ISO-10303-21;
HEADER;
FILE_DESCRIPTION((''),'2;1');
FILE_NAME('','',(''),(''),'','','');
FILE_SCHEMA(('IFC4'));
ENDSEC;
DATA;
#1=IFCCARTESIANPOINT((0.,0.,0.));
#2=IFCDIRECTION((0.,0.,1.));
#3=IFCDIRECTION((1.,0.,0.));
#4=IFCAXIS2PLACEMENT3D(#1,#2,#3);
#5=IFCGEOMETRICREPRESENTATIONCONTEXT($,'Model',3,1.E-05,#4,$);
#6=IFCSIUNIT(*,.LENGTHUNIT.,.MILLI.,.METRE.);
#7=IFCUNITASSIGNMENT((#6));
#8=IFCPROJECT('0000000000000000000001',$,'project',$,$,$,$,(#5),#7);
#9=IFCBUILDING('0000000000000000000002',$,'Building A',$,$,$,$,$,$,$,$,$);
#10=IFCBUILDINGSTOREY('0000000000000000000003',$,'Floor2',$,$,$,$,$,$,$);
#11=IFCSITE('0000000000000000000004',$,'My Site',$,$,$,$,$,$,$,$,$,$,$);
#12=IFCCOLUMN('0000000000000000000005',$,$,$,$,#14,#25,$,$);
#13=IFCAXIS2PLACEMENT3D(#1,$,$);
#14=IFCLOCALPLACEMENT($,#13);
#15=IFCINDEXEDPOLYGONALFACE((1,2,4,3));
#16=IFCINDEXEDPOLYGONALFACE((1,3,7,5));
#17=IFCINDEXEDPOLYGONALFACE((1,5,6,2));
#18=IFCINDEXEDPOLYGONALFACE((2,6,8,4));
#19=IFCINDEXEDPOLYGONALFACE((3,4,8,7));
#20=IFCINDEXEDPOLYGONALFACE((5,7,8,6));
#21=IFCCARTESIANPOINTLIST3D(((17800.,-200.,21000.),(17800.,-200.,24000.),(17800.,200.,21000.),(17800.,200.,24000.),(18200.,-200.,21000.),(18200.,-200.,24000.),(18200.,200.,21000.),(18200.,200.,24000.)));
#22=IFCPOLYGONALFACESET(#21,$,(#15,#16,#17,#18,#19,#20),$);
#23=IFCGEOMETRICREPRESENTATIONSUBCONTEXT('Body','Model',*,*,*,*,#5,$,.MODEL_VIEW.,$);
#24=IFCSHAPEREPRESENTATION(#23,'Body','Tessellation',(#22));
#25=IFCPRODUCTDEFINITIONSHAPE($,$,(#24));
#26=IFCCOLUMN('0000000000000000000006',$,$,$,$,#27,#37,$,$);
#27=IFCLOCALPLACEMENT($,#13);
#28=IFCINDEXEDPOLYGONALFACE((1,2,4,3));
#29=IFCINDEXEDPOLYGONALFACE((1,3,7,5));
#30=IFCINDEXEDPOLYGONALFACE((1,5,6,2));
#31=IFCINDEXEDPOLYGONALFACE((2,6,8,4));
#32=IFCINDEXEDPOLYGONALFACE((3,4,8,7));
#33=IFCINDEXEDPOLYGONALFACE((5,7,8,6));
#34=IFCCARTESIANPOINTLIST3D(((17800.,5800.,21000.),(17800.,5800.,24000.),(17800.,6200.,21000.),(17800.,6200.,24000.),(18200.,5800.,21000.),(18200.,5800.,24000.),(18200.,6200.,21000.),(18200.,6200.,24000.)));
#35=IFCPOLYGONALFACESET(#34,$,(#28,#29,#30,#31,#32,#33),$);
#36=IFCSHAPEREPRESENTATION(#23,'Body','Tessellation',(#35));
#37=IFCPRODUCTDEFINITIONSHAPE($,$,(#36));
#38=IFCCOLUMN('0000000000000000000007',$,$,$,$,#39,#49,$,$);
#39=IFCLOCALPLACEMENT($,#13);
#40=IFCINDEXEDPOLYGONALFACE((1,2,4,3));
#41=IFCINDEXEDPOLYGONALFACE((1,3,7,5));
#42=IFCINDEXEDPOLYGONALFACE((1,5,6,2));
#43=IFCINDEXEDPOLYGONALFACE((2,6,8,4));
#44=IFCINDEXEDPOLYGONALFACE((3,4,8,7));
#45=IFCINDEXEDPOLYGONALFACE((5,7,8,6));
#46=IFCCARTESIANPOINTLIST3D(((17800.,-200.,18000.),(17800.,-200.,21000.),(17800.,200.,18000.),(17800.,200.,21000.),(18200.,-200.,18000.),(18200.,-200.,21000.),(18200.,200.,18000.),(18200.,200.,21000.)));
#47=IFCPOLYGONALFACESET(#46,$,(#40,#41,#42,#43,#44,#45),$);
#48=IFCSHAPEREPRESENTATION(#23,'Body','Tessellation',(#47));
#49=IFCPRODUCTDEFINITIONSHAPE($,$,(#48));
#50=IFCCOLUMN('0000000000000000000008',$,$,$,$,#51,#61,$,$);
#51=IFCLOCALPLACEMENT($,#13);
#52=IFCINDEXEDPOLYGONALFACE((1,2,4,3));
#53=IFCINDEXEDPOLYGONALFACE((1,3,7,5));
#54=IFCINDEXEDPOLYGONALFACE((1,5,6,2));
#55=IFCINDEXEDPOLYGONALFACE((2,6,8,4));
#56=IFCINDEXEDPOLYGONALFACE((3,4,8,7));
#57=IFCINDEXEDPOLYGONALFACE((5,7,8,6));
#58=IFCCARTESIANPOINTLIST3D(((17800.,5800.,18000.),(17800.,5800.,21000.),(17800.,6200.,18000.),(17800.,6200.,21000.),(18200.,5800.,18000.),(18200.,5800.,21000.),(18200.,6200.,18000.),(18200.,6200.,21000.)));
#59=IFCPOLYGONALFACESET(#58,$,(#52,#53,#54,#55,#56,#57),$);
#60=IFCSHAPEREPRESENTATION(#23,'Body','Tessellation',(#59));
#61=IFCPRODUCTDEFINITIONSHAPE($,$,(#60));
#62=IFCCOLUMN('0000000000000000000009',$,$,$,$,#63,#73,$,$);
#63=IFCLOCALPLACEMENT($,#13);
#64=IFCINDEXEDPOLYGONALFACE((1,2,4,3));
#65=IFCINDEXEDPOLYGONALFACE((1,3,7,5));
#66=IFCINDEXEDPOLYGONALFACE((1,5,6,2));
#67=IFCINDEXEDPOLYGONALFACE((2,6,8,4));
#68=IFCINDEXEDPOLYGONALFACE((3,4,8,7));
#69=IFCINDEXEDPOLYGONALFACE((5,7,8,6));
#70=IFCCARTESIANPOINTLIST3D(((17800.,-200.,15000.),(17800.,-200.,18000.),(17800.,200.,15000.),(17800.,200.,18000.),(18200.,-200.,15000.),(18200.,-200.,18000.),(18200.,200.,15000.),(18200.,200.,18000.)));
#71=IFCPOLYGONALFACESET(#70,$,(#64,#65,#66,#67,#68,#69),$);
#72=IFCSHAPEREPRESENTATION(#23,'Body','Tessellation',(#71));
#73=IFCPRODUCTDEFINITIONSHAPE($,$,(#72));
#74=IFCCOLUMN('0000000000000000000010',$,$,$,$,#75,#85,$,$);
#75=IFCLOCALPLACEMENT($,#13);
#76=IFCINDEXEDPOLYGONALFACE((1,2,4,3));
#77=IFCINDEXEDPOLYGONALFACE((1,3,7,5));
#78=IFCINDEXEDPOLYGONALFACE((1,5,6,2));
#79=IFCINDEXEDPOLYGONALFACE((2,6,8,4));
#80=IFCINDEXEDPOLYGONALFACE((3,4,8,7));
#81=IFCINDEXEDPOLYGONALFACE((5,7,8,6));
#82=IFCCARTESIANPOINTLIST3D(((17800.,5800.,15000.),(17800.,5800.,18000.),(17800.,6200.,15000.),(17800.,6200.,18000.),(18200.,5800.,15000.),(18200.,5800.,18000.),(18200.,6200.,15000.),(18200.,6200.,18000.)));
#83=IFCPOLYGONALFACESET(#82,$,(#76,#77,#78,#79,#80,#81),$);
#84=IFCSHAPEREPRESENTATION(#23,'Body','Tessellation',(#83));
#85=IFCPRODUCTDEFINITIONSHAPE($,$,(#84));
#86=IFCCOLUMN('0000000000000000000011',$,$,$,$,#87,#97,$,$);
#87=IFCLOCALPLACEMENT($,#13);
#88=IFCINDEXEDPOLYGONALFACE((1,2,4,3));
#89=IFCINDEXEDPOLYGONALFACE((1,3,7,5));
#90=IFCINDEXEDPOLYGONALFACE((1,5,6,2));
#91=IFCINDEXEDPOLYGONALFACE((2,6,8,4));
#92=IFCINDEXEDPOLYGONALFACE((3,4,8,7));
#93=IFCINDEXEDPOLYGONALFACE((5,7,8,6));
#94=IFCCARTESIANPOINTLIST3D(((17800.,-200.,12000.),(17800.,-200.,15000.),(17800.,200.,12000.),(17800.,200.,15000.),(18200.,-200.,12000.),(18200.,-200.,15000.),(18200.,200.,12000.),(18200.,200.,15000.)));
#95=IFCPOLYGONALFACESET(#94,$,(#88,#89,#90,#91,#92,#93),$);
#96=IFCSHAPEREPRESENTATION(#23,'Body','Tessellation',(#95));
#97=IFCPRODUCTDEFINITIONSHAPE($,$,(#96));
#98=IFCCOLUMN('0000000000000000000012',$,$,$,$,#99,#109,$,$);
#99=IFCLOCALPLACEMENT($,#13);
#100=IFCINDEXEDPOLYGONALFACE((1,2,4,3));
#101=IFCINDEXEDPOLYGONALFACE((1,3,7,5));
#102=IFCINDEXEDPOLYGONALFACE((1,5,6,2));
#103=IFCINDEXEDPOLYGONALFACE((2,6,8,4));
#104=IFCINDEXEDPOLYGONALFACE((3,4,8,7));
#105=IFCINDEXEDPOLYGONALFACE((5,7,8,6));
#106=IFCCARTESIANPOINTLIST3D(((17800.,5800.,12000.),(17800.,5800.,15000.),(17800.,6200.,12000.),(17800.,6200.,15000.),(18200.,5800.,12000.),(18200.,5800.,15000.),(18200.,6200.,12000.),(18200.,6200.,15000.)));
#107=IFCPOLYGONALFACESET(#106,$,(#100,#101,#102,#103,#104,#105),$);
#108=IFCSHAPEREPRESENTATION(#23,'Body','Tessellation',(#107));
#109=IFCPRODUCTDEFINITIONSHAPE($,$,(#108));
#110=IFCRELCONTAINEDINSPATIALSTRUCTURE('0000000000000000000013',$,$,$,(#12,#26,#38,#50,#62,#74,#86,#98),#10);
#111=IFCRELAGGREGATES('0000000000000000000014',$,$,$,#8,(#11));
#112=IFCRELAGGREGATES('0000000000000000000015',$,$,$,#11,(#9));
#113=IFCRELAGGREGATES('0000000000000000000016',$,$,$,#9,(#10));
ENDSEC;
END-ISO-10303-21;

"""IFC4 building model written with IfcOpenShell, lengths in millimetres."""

from ifc_helpers import new_model, si_unit, frame, origin_with_axes, place, context, subcontext, project, spatial, line, indexed_curve, outline, extrude, element, save


model = new_model("IFC4")

# Units and contexts
model_context = context("Model", 3, precision=1e-05, world=origin_with_axes())
body_context = subcontext(model_context, "Body", "Model", "MODEL_VIEW")
ifc_project = project(units=[si_unit("LENGTHUNIT", "METRE", prefix="MILLI")], contexts=[model_context])

# Site, building, storey
site = spatial("IfcSite", under=ifc_project, Name="My Site")
building = spatial("IfcBuilding", under=site, Name="Building A")
storey = spatial("IfcBuildingStorey", under=building, Name="Floor2")

# Columns
for number, where, z_axis, x_axis in (
    (1, (18000.0, 0.0, 21000.0), (0.0, 0.0, 1.0), (1.0, 0.0, 0.0)),
    (2, (18000.0, 6000.0, 21000.0), (0.0, 0.0, 1.0), (1.0, 0.0, 0.0)),
    (3, (18000.0, 0.0, 18000.0), (0.0, 0.0, 1.0), (1.0, 0.0, 0.0)),
    (4, (18000.0, 6000.0, 18000.0), (0.0, 0.0, 1.0), (1.0, 0.0, 0.0)),
    (5, (18000.0, 0.0, 15000.0), (0.0, 0.0, 1.0), (1.0, 0.0, 0.0)),
    (6, (18000.0, 6000.0, 15000.0), (0.0, 0.0, 1.0), (1.0, 0.0, 0.0)),
    (7, (18000.0, 0.0, 12000.0), (0.0, 0.0, 1.0), (1.0, 0.0, 0.0)),
    (8, (18000.0, 6000.0, 12000.0), (0.0, 0.0, 1.0), (1.0, 0.0, 0.0)),
):
    element("IfcColumn", number, at=place(None, frame(where, z_axis=z_axis, x_axis=x_axis)), inside=storey, context=body_context, shape_type="SweptSolid", body=[
        extrude(outline(indexed_curve([(-200.0, -200.0), (200.0, -200.0), (200.0, 200.0), (-200.0, 200.0)], segments=[line(1, 2, 3, 4, 1)])), origin_with_axes(), (0.0, 0.0, 1.0), 3000.0),
    ])

save(model, "model.ifc")
